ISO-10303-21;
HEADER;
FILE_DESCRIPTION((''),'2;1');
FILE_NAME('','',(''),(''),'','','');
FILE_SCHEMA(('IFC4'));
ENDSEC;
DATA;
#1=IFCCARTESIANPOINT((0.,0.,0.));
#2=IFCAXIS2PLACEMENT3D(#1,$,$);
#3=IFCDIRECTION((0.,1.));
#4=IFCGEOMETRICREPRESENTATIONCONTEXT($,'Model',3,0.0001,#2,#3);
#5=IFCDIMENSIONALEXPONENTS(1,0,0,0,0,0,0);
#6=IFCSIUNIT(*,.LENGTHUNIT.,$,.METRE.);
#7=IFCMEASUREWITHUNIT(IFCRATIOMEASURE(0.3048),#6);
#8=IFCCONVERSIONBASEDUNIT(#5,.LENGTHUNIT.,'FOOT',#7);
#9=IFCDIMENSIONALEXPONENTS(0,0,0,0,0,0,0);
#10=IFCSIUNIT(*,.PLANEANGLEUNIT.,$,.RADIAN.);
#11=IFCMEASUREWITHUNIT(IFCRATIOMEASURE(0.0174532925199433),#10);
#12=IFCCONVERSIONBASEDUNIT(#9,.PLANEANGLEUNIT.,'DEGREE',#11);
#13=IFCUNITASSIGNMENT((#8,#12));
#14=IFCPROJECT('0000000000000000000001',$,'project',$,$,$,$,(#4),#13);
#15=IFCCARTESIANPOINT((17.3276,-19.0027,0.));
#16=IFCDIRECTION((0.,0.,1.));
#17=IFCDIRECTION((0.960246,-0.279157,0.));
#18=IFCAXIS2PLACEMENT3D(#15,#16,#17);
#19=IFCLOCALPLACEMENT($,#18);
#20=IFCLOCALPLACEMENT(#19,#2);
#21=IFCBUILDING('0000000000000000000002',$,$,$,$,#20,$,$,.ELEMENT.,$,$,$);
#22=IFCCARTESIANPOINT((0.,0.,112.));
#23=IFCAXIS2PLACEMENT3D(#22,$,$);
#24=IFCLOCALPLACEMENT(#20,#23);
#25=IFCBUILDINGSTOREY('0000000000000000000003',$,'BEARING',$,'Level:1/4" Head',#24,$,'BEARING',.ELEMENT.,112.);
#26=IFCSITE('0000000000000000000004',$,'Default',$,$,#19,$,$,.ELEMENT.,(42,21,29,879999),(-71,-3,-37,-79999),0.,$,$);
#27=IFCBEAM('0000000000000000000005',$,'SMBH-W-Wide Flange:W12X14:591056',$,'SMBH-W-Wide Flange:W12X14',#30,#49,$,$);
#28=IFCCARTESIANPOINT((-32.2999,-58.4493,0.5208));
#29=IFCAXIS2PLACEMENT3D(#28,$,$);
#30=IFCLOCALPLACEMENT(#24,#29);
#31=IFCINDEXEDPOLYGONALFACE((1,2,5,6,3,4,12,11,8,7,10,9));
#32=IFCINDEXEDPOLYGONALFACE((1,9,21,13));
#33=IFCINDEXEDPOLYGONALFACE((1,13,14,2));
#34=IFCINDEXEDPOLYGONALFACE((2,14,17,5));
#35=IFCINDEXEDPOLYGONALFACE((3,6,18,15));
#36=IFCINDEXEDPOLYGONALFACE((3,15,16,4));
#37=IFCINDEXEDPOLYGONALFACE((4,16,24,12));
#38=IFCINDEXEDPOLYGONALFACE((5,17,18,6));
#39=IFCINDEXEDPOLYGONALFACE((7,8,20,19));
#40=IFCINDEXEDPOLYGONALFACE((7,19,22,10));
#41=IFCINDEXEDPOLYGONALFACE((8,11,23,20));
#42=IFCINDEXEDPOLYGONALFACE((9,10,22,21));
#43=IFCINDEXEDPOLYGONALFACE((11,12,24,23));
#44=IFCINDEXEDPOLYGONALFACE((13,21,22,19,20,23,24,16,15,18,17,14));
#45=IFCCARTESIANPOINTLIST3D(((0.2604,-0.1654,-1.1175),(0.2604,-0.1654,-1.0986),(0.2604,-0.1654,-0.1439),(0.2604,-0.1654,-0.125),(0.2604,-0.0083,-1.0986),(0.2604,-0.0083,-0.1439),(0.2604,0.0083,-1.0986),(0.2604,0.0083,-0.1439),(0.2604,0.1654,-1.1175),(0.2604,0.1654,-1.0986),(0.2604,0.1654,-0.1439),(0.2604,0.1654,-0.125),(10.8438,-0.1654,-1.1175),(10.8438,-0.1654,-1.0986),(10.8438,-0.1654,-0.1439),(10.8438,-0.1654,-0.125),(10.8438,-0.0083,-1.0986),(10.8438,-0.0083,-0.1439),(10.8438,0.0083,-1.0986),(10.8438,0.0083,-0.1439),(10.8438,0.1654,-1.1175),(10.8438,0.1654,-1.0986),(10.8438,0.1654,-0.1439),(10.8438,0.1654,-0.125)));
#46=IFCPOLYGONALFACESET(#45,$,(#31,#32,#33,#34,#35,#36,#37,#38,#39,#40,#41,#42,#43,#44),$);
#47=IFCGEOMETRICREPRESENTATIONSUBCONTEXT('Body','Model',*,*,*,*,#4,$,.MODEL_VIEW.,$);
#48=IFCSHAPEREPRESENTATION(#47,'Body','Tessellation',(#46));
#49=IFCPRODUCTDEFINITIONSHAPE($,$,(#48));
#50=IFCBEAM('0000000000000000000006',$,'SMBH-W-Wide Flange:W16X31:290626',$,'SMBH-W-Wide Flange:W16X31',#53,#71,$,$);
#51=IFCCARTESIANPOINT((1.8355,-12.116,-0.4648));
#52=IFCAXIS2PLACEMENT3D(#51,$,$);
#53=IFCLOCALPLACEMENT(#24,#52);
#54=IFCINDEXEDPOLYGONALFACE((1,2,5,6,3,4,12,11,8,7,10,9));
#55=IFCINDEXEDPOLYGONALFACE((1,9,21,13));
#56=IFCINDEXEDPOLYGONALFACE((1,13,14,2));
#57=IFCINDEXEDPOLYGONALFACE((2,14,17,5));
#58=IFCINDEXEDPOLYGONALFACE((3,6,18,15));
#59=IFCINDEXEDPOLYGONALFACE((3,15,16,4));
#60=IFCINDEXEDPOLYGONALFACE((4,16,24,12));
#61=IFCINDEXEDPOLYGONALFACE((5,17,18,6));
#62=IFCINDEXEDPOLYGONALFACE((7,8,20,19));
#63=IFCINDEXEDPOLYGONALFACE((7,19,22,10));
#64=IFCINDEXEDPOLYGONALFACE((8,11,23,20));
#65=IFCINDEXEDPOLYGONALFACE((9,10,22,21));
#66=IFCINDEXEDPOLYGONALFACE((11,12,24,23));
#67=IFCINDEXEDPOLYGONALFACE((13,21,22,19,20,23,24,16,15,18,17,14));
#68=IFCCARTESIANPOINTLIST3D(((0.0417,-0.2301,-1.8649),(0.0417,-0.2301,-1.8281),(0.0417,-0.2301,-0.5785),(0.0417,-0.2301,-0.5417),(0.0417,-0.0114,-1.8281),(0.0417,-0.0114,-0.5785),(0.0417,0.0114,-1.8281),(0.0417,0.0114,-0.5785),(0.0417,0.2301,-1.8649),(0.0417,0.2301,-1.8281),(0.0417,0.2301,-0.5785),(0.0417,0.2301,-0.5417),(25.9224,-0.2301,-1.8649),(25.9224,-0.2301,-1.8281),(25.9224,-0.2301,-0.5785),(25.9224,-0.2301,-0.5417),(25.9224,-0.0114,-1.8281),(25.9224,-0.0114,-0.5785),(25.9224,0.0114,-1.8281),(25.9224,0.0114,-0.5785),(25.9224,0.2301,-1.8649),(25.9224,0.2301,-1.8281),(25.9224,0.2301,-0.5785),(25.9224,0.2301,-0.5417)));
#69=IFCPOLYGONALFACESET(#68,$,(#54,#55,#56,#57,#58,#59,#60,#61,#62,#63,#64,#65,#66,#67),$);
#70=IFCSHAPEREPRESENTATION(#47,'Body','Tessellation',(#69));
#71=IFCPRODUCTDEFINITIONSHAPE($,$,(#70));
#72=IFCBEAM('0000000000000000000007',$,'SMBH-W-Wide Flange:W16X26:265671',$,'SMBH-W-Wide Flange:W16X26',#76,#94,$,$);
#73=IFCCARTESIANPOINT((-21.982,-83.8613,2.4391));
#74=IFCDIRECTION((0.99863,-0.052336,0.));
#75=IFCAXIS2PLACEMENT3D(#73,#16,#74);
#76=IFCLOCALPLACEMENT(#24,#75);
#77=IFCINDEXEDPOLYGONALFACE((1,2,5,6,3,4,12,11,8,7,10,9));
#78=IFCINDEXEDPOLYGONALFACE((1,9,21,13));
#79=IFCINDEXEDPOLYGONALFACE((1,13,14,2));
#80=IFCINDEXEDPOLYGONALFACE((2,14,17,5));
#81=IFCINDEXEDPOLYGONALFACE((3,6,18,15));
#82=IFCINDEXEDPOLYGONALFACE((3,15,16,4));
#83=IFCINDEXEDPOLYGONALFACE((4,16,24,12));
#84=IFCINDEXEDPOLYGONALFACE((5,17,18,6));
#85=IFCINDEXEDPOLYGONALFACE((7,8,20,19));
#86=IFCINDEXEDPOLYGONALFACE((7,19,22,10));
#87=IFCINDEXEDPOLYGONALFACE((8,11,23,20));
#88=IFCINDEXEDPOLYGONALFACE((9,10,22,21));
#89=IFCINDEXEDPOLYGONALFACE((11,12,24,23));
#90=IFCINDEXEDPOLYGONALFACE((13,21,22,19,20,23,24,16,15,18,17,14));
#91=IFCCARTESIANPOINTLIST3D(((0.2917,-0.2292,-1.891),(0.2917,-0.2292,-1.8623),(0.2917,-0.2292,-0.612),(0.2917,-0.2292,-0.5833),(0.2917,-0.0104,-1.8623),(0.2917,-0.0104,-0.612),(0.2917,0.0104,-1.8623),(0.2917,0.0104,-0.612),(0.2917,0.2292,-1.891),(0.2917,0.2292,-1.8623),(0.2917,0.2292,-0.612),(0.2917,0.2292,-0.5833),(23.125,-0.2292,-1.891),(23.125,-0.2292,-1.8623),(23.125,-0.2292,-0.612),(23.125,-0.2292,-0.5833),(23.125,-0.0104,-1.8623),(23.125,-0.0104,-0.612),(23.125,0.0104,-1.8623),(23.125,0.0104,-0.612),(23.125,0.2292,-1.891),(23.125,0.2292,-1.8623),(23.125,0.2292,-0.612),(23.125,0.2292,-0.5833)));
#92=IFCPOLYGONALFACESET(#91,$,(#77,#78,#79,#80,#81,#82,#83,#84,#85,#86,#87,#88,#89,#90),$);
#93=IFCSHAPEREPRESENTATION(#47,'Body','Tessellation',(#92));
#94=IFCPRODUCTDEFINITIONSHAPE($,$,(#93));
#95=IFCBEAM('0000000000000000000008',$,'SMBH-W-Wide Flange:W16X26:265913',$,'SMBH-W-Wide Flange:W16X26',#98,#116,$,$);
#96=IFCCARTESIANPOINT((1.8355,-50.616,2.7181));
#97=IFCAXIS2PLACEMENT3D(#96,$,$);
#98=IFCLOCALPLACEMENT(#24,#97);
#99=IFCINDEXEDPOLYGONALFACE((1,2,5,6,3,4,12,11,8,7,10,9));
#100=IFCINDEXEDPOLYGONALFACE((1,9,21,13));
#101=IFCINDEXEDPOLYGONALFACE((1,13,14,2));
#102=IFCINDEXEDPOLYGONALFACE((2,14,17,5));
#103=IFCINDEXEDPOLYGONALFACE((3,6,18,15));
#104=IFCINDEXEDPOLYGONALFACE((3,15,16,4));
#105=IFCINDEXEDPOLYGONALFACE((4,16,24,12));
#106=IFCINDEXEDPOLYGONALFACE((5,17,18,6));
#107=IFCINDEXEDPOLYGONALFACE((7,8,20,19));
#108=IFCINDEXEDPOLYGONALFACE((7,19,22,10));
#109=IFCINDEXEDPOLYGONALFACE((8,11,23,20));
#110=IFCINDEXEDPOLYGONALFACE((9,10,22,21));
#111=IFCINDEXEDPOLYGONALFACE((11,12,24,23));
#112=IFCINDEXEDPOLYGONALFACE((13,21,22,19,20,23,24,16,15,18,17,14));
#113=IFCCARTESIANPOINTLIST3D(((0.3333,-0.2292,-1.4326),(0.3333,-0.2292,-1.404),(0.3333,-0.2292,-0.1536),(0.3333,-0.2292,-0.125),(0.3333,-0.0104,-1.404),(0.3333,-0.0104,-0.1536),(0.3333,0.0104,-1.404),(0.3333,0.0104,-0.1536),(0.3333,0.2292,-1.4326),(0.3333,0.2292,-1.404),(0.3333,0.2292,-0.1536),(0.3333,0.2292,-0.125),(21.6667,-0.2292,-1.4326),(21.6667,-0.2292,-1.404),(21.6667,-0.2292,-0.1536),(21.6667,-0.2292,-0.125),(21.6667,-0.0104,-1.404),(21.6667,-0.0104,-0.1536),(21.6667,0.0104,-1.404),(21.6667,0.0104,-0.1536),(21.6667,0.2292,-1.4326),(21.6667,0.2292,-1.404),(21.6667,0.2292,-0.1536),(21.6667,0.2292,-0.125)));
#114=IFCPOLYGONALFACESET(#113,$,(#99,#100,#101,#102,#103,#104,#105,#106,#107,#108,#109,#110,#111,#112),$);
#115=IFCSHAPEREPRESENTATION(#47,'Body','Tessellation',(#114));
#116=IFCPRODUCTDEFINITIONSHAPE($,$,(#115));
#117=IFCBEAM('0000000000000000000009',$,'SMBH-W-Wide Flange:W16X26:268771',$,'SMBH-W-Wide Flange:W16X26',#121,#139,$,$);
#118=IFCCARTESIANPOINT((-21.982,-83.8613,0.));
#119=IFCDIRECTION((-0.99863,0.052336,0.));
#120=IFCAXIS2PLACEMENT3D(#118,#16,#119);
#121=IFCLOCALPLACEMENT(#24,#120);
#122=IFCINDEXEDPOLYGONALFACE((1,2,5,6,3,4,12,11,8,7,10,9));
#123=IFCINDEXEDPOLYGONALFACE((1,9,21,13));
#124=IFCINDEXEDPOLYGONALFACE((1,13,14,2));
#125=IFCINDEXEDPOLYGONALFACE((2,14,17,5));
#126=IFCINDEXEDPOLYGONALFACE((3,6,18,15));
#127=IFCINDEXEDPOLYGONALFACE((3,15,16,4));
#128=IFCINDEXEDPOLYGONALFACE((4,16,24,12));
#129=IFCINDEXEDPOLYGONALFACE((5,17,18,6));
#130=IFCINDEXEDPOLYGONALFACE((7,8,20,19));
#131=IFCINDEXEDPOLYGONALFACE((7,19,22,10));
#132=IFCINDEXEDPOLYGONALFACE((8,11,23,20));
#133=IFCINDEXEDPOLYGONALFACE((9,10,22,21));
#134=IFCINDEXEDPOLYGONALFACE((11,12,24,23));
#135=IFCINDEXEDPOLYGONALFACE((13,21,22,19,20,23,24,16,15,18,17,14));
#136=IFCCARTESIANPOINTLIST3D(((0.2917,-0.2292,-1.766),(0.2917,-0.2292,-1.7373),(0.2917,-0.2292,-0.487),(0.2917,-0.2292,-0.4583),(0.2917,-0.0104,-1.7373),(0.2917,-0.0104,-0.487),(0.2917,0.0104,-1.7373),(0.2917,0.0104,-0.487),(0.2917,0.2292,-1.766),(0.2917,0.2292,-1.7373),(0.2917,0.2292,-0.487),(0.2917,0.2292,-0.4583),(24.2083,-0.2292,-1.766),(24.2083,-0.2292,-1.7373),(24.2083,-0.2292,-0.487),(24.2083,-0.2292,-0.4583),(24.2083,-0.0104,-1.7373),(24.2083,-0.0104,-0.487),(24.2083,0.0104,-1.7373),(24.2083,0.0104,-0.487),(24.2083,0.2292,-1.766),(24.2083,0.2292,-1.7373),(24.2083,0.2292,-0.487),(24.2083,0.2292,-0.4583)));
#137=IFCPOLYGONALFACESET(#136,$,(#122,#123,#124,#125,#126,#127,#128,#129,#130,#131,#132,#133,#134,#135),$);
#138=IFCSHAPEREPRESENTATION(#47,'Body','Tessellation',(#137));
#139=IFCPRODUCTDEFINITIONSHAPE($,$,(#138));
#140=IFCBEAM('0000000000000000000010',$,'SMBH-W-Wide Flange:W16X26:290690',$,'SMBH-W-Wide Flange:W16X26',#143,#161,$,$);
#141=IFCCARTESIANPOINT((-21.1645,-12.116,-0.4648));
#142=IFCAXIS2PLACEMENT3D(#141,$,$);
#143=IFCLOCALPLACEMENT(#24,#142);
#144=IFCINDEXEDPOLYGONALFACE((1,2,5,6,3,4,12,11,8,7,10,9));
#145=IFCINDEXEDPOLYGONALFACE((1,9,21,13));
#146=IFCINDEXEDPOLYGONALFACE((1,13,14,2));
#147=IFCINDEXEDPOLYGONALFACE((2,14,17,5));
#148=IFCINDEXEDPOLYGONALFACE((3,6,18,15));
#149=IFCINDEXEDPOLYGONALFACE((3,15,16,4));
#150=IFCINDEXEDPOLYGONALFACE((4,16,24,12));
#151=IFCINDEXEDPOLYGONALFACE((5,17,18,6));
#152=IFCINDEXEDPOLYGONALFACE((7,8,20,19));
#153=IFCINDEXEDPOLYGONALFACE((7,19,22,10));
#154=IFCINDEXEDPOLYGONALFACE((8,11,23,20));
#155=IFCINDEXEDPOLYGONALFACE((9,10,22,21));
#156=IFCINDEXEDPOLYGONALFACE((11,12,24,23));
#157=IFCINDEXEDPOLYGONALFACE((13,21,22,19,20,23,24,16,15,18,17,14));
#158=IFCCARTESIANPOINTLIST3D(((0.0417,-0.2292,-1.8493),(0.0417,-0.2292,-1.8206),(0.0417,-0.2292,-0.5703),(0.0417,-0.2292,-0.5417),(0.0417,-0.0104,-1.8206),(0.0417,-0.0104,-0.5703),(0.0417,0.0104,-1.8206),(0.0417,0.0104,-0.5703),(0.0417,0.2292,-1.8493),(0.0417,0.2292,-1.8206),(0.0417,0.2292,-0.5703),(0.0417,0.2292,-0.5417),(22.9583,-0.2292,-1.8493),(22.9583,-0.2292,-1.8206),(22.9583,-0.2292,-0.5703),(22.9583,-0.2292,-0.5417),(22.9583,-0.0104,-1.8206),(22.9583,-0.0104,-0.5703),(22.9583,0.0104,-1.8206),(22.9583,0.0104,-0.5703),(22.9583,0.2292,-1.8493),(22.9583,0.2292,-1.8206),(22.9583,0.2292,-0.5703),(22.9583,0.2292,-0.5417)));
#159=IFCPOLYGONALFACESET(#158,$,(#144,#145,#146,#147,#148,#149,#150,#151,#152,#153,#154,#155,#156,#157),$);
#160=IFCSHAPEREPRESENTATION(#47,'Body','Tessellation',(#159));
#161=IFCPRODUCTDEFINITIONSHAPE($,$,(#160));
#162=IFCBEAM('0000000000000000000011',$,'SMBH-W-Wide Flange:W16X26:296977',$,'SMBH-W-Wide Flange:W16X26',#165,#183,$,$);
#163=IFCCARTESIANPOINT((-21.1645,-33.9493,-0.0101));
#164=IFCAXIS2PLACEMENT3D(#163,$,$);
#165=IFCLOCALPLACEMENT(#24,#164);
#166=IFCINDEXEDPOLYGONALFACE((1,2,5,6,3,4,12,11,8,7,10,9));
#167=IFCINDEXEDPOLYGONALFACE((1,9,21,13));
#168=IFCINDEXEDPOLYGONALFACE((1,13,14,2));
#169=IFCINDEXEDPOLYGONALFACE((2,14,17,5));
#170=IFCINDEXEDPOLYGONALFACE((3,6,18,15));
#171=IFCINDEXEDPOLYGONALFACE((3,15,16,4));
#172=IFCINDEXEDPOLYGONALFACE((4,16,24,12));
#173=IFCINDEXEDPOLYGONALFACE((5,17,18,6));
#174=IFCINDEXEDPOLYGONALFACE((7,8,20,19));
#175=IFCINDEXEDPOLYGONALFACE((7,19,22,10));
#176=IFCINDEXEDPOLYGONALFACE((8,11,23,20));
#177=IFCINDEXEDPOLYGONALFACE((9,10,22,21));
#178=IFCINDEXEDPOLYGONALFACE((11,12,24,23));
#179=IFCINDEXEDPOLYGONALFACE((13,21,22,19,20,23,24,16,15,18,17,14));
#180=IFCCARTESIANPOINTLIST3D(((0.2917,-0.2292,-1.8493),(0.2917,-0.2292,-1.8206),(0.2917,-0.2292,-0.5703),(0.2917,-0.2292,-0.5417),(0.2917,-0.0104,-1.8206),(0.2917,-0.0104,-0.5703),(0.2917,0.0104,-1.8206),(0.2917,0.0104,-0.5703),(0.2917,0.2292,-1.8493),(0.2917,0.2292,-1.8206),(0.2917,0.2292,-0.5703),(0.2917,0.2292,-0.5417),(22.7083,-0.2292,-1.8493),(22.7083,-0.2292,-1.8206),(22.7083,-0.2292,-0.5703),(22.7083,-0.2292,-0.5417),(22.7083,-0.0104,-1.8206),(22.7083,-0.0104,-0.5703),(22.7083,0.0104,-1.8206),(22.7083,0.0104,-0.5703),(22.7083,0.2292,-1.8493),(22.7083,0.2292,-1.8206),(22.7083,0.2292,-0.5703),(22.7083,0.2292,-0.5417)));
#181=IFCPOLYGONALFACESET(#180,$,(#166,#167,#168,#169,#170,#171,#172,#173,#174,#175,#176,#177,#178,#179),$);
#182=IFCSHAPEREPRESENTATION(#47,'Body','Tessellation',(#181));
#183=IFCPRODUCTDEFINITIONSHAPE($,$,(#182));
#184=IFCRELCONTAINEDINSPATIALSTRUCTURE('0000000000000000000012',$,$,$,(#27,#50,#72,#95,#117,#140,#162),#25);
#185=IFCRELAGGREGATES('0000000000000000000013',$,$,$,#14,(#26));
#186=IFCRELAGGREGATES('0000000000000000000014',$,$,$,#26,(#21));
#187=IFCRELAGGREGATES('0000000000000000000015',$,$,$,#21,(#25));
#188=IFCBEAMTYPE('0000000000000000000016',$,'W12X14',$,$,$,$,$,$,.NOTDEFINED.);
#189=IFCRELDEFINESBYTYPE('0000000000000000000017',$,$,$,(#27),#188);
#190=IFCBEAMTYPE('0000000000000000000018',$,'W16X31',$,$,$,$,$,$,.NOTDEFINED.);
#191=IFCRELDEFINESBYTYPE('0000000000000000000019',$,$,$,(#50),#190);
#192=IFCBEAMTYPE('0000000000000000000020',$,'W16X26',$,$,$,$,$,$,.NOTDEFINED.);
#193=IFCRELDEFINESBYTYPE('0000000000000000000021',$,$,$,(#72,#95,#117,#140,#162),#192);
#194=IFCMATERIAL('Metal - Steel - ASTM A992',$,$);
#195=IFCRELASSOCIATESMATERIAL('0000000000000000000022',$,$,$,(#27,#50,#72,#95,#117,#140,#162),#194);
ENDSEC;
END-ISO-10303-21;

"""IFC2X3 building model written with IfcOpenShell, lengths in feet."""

from ifc_helpers import new_model, entity, si_unit, converted_unit, direction, frame, frame_2d, origin, place, context, subcontext, project, spatial, i_section, extrude, material, type_object, element, save


model = new_model("IFC2X3")

# Units and contexts
model_context = context("Model", 3, precision=0.0001, world=origin(), true_north=direction((0.0, 1.0)))
body_context = subcontext(model_context, "Body", "Model", "MODEL_VIEW")
ifc_project = project(units=[converted_unit("LENGTHUNIT", "FOOT", entity("IfcRatioMeasure", 0.3048), si_unit("LENGTHUNIT", "METRE"), dimensions=[1, 0, 0, 0, 0, 0, 0]), converted_unit("PLANEANGLEUNIT", "DEGREE", entity("IfcRatioMeasure", 0.0174532925199433), si_unit("PLANEANGLEUNIT", "RADIAN"), dimensions=[0, 0, 0, 0, 0, 0, 0])], contexts=[model_context])

# Site, building, storey
site_placement = place(None, frame((17.3276, -19.0027, 0.0), z_axis=(0.0, 0.0, 1.0), x_axis=(0.960246, -0.279157, 0.0)))
site = spatial("IfcSite", under=ifc_project, at=site_placement, Name="Default", CompositionType="ELEMENT", RefLatitude=(42, 21, 29, 879999), RefLongitude=(-71, -3, -37, -79999), RefElevation=0.0)
building_placement = place(site_placement, origin())
building = spatial("IfcBuilding", under=site, at=building_placement, CompositionType="ELEMENT")
storey_placement = place(building_placement, frame((0.0, 0.0, 112.0)))
storey = spatial("IfcBuildingStorey", under=building, at=storey_placement, Name="BEARING", ObjectType="Level:1/4\" Head", LongName="BEARING", CompositionType="ELEMENT", Elevation=112.0)

# Beams
ifc_material_1 = material(Name="Metal - Steel - ASTM A992")
beam_type_1 = type_object("IfcBeamType", Name="W12X14", PredefinedType="NOTDEFINED")
beam_1_placement = place(storey_placement, frame((-32.2999, -58.4493, 0.5208)))
element("IfcBeam", 1, at=beam_1_placement, inside=storey, type_object=beam_type_1, material=ifc_material_1, Name="SMBH-W-Wide Flange:W12X14:591056", ObjectType="SMBH-W-Wide Flange:W12X14", context=body_context, shape_type="SweptSolid", body=[
    extrude(i_section(OverallWidth=0.3307, OverallDepth=0.9925, WebThickness=0.0166, FlangeThickness=0.0189, at=frame_2d((0.0, 0.0), x_axis=(0.0, 1.0))), frame((0.2604, 0.0, -0.6213), z_axis=(1.0, 0.0, 0.0), x_axis=(0.0, 0.0, -1.0)), (0.0, 0.0, 1.0), 10.5833),
])
beam_type_2 = type_object("IfcBeamType", Name="W16X31", PredefinedType="NOTDEFINED")
beam_2_placement = place(storey_placement, frame((1.8355, -12.116, -0.4648)))
element("IfcBeam", 2, at=beam_2_placement, inside=storey, type_object=beam_type_2, material=ifc_material_1, Name="SMBH-W-Wide Flange:W16X31:290626", ObjectType="SMBH-W-Wide Flange:W16X31", context=body_context, shape_type="SweptSolid", body=[
    extrude(i_section(OverallWidth=0.4603, OverallDepth=1.3232, WebThickness=0.0228, FlangeThickness=0.0368, at=frame_2d((0.0, 0.0), x_axis=(0.0, 1.0))), frame((0.0417, 0.0, -1.2033), z_axis=(1.0, 0.0, 0.0), x_axis=(0.0, 0.0, -1.0)), (0.0, 0.0, 1.0), 25.8807),
])
beam_type_3 = type_object("IfcBeamType", Name="W16X26", PredefinedType="NOTDEFINED")
beam_3_placement = place(storey_placement, frame((-21.982, -83.8613, 2.4391), z_axis=(0.0, 0.0, 1.0), x_axis=(0.99863, -0.052336, 0.0)))
element("IfcBeam", 3, at=beam_3_placement, inside=storey, type_object=beam_type_3, material=ifc_material_1, Name="SMBH-W-Wide Flange:W16X26:265671", ObjectType="SMBH-W-Wide Flange:W16X26", context=body_context, shape_type="SweptSolid", body=[
    extrude(i_section(OverallWidth=0.4583, OverallDepth=1.3076, WebThickness=0.0208, FlangeThickness=0.0286, at=frame_2d((0.0, 0.0), x_axis=(0.0, 1.0))), frame((0.2917, 0.0, -1.2371), z_axis=(1.0, 0.0, 0.0), x_axis=(0.0, 0.0, -1.0)), (0.0, 0.0, 1.0), 22.8333),
])
beam_4_placement = place(storey_placement, frame((1.8355, -50.616, 2.7181)))
element("IfcBeam", 4, at=beam_4_placement, inside=storey, type_object=beam_type_3, material=ifc_material_1, Name="SMBH-W-Wide Flange:W16X26:265913", ObjectType="SMBH-W-Wide Flange:W16X26", context=body_context, shape_type="SweptSolid", body=[
    extrude(i_section(OverallWidth=0.4583, OverallDepth=1.3076, WebThickness=0.0208, FlangeThickness=0.0286, at=frame_2d((0.0, 0.0), x_axis=(0.0, 1.0))), frame((0.3333, 0.0, -0.7788), z_axis=(1.0, 0.0, 0.0), x_axis=(0.0, 0.0, -1.0)), (0.0, 0.0, 1.0), 21.3333),
])
beam_5_placement = place(storey_placement, frame((-21.982, -83.8613, 0.0), z_axis=(0.0, 0.0, 1.0), x_axis=(-0.99863, 0.052336, 0.0)))
element("IfcBeam", 5, at=beam_5_placement, inside=storey, type_object=beam_type_3, material=ifc_material_1, Name="SMBH-W-Wide Flange:W16X26:268771", ObjectType="SMBH-W-Wide Flange:W16X26", context=body_context, shape_type="SweptSolid", body=[
    extrude(i_section(OverallWidth=0.4583, OverallDepth=1.3076, WebThickness=0.0208, FlangeThickness=0.0286, at=frame_2d((0.0, 0.0), x_axis=(0.0, 1.0))), frame((0.2917, 0.0, -1.1121), z_axis=(1.0, 0.0, 0.0), x_axis=(0.0, 0.0, -1.0)), (0.0, 0.0, 1.0), 23.9167),
])
beam_6_placement = place(storey_placement, frame((-21.1645, -12.116, -0.4648)))
element("IfcBeam", 6, at=beam_6_placement, inside=storey, type_object=beam_type_3, material=ifc_material_1, Name="SMBH-W-Wide Flange:W16X26:290690", ObjectType="SMBH-W-Wide Flange:W16X26", context=body_context, shape_type="SweptSolid", body=[
    extrude(i_section(OverallWidth=0.4583, OverallDepth=1.3076, WebThickness=0.0208, FlangeThickness=0.0286, at=frame_2d((0.0, 0.0), x_axis=(0.0, 1.0))), frame((0.0417, 0.0, -1.1955), z_axis=(1.0, 0.0, 0.0), x_axis=(0.0, 0.0, -1.0)), (0.0, 0.0, 1.0), 22.9167),
])
beam_7_placement = place(storey_placement, frame((-21.1645, -33.9493, -0.0101)))
element("IfcBeam", 7, at=beam_7_placement, inside=storey, type_object=beam_type_3, material=ifc_material_1, Name="SMBH-W-Wide Flange:W16X26:296977", ObjectType="SMBH-W-Wide Flange:W16X26", context=body_context, shape_type="SweptSolid", body=[
    extrude(i_section(OverallWidth=0.4583, OverallDepth=1.3076, WebThickness=0.0208, FlangeThickness=0.0286, at=frame_2d((0.0, 0.0), x_axis=(0.0, 1.0))), frame((0.2917, 0.0, -1.1955), z_axis=(1.0, 0.0, 0.0), x_axis=(0.0, 0.0, -1.0)), (0.0, 0.0, 1.0), 22.4167),
])

save(model, "model.ifc")
